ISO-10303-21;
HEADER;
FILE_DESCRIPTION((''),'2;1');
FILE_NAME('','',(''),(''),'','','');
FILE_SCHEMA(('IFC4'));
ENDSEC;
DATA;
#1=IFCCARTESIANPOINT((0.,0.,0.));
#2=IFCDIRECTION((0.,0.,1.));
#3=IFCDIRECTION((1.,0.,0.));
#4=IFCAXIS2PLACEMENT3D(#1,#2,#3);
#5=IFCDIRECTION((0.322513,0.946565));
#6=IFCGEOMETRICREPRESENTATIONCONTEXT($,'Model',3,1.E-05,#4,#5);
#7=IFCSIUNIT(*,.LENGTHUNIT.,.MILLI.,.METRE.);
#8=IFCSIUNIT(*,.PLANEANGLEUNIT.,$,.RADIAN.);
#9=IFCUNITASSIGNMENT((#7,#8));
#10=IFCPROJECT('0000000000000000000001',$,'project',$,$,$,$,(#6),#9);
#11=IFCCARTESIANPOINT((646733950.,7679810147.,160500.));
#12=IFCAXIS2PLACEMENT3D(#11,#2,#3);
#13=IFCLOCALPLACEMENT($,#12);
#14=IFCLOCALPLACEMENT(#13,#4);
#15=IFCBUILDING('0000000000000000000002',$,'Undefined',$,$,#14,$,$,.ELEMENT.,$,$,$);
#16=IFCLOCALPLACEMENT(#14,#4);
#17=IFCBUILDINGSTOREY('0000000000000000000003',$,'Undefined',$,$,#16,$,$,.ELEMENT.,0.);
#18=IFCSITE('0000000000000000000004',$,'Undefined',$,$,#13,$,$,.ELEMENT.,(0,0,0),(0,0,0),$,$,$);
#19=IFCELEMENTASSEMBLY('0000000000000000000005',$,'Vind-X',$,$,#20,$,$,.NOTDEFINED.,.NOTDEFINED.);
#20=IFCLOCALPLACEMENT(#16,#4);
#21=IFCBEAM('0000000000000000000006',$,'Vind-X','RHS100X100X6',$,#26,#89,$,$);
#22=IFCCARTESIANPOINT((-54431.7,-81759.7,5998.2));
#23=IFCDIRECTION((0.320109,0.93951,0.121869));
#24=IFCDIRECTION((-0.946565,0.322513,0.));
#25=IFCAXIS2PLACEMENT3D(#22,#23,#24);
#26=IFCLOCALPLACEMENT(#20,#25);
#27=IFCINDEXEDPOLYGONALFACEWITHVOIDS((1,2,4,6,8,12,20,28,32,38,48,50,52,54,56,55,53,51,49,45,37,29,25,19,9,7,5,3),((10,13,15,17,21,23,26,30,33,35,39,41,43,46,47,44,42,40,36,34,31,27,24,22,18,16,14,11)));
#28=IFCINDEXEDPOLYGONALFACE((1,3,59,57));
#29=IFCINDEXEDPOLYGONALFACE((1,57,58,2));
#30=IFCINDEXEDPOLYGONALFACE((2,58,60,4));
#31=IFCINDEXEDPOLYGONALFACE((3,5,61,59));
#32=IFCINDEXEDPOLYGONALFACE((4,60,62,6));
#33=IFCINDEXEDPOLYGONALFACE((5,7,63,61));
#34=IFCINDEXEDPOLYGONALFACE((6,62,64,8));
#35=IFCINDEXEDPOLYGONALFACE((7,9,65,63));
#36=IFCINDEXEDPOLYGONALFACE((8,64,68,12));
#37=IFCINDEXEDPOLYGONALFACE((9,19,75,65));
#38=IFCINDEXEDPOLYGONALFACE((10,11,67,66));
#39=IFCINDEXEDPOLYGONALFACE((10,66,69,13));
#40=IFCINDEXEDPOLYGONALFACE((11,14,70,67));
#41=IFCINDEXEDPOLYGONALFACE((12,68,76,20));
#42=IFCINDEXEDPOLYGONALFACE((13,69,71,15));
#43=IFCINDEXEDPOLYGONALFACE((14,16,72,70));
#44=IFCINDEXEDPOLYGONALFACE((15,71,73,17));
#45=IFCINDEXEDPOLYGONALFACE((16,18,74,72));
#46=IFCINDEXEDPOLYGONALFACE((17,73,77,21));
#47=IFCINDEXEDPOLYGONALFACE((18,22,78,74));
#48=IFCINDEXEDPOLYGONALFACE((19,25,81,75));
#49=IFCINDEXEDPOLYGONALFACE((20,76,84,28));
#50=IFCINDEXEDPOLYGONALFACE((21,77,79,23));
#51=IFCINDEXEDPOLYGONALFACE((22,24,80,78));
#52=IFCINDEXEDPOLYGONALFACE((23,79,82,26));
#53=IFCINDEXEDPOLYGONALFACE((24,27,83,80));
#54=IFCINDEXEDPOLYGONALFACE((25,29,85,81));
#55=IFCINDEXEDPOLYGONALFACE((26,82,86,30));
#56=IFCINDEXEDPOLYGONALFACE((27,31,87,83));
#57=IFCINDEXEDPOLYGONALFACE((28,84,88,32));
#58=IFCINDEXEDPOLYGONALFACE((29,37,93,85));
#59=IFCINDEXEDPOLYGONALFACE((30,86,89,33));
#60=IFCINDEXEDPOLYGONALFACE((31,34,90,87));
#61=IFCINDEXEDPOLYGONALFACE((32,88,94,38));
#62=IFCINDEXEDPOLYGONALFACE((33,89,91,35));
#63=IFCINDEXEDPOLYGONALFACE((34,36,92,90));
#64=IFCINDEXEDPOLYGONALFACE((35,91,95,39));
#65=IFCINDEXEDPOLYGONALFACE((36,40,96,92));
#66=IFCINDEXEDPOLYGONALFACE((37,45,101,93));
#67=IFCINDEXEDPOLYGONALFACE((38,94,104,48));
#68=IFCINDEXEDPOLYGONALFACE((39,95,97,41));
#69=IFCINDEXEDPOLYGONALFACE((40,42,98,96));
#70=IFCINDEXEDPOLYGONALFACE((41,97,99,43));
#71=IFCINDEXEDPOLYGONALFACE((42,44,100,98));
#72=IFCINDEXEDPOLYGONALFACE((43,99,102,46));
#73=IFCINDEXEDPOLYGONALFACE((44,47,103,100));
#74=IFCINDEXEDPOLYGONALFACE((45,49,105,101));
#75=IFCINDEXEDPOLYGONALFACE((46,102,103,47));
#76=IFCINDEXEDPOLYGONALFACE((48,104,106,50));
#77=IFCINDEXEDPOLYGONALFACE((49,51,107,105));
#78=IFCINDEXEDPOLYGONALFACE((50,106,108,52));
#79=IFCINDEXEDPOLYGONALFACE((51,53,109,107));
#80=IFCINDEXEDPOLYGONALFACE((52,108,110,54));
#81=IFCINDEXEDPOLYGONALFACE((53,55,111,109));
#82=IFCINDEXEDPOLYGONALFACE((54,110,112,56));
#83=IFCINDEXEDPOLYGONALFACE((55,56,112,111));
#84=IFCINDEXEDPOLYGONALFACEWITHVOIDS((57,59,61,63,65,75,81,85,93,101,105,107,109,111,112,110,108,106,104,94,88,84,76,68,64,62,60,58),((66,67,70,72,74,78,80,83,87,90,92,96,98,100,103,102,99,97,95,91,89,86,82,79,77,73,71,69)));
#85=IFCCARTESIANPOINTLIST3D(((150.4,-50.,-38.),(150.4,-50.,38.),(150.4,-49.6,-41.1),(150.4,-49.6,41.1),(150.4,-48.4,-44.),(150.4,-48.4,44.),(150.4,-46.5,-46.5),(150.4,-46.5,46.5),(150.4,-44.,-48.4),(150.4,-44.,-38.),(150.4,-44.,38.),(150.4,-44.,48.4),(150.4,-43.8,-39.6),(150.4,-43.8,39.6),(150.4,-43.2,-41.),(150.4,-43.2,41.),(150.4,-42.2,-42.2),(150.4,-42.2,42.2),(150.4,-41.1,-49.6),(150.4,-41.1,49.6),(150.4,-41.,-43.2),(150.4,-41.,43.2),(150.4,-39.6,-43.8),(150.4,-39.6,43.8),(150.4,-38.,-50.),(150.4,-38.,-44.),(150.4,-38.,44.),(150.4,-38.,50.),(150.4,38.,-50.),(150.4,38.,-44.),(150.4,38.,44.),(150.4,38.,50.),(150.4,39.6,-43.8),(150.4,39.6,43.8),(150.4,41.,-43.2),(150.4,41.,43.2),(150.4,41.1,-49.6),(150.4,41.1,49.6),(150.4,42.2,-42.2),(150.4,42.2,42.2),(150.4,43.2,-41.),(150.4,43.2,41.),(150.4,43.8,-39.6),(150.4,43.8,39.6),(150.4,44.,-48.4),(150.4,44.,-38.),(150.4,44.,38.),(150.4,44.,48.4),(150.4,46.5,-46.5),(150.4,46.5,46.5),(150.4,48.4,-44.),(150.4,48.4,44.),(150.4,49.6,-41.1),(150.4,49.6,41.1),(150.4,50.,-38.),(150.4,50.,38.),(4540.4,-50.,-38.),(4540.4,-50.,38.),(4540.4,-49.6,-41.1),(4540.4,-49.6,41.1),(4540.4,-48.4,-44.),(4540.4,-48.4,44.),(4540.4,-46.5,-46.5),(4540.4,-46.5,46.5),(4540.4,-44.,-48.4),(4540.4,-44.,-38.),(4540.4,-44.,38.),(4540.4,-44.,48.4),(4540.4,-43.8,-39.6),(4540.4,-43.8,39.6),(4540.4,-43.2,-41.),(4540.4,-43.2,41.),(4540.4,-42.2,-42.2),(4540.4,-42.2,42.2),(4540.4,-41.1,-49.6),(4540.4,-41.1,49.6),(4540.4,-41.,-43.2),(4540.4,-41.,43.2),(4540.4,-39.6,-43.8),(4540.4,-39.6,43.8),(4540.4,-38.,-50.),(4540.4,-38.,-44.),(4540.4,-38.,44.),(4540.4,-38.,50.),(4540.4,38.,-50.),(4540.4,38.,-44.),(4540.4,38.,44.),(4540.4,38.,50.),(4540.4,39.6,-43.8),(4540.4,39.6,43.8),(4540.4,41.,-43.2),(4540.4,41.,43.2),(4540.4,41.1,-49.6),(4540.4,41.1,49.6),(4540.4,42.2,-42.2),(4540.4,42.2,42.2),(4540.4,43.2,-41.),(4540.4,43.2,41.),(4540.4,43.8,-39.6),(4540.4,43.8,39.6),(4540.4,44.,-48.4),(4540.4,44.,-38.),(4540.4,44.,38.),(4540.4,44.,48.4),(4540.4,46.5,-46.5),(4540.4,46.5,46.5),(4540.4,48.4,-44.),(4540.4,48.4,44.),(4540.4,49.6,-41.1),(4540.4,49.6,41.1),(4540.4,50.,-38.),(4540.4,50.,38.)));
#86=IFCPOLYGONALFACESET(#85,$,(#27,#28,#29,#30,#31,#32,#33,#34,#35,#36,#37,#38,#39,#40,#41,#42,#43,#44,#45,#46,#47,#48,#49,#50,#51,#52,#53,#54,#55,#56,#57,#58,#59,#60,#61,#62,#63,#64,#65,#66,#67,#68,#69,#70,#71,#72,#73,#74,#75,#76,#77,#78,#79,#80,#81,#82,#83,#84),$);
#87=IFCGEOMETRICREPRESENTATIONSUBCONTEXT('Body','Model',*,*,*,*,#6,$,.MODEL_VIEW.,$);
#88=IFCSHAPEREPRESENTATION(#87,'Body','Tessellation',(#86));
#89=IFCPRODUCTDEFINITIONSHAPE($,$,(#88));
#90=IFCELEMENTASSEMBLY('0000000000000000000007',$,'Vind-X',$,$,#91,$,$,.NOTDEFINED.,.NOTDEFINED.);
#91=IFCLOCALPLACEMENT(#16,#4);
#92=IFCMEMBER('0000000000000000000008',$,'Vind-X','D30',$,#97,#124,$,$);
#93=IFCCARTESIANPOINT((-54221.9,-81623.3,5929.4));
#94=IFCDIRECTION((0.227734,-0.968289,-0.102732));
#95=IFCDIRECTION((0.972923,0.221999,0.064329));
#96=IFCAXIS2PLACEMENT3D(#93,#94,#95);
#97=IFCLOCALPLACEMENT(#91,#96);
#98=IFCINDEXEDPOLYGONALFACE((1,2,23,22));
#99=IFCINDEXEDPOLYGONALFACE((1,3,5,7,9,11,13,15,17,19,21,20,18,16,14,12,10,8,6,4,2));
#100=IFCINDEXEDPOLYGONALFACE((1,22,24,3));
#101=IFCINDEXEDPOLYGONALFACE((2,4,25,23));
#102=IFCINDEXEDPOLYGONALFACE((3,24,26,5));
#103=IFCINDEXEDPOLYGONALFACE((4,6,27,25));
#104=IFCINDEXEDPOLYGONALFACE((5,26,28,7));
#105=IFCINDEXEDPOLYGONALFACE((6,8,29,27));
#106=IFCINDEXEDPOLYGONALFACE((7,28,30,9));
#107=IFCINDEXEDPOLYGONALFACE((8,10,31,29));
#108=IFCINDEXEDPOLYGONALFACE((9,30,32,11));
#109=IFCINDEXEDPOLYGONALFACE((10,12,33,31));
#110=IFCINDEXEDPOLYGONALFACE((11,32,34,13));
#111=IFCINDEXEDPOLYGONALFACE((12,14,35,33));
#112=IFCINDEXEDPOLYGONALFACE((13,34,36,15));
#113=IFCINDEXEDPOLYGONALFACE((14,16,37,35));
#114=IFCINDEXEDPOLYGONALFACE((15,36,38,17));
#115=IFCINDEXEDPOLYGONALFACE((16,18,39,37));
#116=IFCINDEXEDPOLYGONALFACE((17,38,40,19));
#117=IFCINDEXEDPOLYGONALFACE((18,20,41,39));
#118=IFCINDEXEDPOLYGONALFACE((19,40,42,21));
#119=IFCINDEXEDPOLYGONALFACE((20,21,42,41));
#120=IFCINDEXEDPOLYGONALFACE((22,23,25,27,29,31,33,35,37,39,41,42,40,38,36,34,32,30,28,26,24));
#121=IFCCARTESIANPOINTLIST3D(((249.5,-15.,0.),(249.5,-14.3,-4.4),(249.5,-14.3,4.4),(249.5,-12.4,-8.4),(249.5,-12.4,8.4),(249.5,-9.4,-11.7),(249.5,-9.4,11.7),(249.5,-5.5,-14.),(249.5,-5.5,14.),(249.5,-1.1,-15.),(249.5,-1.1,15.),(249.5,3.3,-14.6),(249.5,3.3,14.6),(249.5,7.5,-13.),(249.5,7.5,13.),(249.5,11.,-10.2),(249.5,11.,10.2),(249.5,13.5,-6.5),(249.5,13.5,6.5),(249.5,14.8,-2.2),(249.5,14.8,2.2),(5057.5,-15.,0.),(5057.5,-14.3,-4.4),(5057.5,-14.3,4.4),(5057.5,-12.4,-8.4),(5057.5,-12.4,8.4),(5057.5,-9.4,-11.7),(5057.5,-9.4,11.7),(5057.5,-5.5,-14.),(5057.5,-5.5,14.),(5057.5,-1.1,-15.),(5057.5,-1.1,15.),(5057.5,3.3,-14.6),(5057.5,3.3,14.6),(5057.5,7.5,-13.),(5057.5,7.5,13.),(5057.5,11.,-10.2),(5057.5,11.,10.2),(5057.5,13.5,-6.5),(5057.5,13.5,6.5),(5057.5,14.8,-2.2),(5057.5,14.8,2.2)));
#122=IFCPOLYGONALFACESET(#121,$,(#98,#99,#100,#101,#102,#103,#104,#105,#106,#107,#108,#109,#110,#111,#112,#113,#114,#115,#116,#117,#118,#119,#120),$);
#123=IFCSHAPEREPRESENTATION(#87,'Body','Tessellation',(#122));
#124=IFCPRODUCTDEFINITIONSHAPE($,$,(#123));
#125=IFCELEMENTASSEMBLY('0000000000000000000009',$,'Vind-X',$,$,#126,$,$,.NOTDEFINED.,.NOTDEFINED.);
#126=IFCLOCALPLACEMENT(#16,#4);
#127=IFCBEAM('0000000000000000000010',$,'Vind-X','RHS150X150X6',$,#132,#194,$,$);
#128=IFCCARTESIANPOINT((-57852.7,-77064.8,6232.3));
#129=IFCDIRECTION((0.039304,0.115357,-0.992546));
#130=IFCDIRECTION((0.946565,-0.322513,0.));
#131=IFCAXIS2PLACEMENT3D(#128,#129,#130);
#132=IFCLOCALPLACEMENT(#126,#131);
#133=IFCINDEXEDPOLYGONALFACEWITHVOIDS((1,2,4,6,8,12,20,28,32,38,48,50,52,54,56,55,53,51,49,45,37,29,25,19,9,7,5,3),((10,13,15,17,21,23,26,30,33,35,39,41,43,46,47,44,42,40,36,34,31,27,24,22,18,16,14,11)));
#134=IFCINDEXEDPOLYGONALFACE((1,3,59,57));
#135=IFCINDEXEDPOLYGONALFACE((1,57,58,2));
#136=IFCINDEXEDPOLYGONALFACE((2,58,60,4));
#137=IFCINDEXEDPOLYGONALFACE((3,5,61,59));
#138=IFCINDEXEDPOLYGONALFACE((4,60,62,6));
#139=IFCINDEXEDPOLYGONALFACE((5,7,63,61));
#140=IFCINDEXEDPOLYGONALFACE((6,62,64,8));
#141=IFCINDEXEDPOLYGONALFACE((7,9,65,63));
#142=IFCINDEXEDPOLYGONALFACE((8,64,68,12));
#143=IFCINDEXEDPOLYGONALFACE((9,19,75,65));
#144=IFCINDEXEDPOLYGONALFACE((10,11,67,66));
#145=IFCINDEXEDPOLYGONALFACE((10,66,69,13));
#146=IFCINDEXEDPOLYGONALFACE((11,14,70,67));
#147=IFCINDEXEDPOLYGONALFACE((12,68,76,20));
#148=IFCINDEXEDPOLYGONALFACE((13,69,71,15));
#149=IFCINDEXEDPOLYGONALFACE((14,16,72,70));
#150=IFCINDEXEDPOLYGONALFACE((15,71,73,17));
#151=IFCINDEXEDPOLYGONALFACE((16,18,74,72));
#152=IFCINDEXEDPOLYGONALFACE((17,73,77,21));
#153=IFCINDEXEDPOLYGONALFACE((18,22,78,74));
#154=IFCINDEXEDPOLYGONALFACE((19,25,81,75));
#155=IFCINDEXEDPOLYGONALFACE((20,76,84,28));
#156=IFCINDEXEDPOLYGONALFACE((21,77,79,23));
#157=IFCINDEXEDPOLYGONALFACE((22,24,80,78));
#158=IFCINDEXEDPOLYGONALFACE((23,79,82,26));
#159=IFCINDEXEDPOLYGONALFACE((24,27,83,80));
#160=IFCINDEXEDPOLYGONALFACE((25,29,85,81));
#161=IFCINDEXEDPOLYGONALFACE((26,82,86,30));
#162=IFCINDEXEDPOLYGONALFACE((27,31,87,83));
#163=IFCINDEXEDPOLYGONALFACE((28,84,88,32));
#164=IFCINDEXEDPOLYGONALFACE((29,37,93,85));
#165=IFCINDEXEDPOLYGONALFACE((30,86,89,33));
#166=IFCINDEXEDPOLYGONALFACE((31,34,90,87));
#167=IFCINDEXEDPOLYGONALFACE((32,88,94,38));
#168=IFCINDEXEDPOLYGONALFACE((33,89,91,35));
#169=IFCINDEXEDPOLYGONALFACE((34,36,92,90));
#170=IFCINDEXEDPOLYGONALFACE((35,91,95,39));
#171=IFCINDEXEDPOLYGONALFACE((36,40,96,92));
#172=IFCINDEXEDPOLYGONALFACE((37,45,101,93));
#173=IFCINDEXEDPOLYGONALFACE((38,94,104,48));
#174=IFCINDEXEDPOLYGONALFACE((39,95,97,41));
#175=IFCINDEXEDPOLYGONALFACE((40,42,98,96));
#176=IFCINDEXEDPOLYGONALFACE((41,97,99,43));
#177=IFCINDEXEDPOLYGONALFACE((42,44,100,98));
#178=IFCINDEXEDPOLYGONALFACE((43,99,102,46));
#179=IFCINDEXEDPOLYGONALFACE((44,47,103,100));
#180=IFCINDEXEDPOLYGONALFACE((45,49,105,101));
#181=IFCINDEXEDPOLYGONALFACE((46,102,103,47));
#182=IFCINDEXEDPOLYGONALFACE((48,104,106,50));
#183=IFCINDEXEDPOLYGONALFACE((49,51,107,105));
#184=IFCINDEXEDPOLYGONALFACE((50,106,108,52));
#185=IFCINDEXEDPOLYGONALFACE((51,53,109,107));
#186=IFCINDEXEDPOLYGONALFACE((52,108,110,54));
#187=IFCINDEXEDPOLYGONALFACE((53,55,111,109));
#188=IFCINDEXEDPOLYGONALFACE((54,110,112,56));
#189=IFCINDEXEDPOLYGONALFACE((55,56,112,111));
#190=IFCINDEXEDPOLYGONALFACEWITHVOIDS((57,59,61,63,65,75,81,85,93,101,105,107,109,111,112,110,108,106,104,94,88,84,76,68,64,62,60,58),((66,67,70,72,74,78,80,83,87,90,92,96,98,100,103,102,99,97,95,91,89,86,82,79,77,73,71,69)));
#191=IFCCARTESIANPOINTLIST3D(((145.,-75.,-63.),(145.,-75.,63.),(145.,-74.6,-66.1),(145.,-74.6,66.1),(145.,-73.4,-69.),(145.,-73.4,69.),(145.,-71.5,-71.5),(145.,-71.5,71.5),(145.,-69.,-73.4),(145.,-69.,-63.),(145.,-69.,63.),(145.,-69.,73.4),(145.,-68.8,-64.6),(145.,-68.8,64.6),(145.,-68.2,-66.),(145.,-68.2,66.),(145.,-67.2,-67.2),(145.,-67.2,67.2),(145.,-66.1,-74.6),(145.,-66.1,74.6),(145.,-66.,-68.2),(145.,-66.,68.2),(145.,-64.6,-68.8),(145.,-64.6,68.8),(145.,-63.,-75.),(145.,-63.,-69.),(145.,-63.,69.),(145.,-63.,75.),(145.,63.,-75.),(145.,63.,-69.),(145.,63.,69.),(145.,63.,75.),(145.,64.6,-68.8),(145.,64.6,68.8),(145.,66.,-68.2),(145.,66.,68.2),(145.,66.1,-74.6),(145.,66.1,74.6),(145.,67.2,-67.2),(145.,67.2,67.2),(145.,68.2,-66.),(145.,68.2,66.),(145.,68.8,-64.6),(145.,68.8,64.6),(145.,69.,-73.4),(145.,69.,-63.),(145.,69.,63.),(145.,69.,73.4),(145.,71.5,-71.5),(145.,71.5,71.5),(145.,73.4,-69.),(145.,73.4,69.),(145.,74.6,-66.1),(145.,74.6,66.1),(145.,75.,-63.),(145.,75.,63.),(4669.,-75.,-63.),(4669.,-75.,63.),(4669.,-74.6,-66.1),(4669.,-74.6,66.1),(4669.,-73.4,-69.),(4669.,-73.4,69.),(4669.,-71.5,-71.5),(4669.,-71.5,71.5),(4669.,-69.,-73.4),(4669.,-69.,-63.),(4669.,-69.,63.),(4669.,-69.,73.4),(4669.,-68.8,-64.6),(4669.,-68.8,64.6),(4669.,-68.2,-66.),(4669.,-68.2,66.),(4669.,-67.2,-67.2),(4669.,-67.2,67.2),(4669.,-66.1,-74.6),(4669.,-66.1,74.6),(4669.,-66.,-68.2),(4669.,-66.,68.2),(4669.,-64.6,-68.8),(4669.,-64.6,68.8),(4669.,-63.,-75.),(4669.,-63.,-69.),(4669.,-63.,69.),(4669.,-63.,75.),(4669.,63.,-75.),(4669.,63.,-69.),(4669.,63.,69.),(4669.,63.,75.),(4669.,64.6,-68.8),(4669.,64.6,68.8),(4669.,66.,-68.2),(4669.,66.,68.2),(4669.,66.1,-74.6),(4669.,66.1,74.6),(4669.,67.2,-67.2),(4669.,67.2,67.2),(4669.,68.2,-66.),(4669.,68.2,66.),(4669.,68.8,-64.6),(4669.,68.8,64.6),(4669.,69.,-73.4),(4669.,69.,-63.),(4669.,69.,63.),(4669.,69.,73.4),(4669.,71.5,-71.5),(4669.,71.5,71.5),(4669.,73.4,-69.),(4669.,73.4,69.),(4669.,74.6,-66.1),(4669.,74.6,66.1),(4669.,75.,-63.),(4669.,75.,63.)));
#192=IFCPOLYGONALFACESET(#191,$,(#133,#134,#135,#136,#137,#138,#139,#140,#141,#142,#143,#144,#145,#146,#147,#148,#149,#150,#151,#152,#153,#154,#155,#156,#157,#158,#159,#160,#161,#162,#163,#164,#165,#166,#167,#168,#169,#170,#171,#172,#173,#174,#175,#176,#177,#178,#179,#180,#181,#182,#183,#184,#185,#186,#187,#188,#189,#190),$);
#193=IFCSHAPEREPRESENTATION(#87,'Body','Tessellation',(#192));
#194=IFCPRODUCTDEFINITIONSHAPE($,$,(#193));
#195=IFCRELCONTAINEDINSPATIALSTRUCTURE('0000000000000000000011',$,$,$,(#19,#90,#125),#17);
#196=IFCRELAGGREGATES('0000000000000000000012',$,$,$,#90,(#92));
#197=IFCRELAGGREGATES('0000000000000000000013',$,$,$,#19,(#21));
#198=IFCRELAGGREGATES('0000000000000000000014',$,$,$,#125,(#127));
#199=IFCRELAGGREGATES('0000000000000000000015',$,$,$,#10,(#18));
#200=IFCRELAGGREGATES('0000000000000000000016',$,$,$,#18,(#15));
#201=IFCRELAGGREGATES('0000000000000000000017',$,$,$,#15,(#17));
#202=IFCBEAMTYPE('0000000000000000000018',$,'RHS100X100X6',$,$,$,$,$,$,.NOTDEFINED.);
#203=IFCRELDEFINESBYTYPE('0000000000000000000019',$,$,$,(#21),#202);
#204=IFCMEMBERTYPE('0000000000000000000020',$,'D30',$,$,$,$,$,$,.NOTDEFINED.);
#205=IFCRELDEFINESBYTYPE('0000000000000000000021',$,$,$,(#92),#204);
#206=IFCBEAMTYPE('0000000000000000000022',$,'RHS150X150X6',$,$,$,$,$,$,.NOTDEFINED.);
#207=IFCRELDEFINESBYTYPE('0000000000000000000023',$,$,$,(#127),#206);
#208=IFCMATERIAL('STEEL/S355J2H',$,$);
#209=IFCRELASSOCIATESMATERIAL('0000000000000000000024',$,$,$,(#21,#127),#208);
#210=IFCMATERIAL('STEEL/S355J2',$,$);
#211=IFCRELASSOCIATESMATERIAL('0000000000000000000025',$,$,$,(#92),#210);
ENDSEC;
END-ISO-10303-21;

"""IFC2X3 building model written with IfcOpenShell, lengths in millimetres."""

from ifc_helpers import new_model, si_unit, direction, frame, origin_with_axes, origin_2d_with_axis, place, context, subcontext, project, spatial, hollow_rectangle, circle, extrude, clip, halfspace, material, type_object, element, aggregate, save


model = new_model("IFC2X3")

# Units and contexts
model_context = context("Model", 3, precision=1e-05, world=origin_with_axes(), true_north=direction((0.322513, 0.946565)))
body_context = subcontext(model_context, "Body", "Model", "MODEL_VIEW")
ifc_project = project(units=[si_unit("LENGTHUNIT", "METRE", prefix="MILLI"), si_unit("PLANEANGLEUNIT", "RADIAN")], contexts=[model_context])

# Site, building, storey
site_placement = place(None, frame((646733950.0, 7679810147.0, 160500.0), z_axis=(0.0, 0.0, 1.0), x_axis=(1.0, 0.0, 0.0)))
site = spatial("IfcSite", under=ifc_project, at=site_placement, Name="Undefined", CompositionType="ELEMENT", RefLatitude=(0, 0, 0), RefLongitude=(0, 0, 0))
building_placement = place(site_placement, origin_with_axes())
building = spatial("IfcBuilding", under=site, at=building_placement, Name="Undefined", CompositionType="ELEMENT")
storey_placement = place(building_placement, origin_with_axes())
storey = spatial("IfcBuildingStorey", under=building, at=storey_placement, Name="Undefined", CompositionType="ELEMENT", Elevation=0.0)

# Element assembly, beam
assembly_1_placement = place(storey_placement, origin_with_axes())
assembly_1 = element("IfcElementAssembly", 1, at=assembly_1_placement, inside=storey, Name="Vind-X", AssemblyPlace="NOTDEFINED", PredefinedType="NOTDEFINED")
ifc_material_1 = material(Name="STEEL/S355J2H")
beam_type_1 = type_object("IfcBeamType", Name="RHS100X100X6", PredefinedType="NOTDEFINED")
beam_1_placement = place(assembly_1_placement, frame((-54431.7, -81759.7, 5998.2), z_axis=(0.320109, 0.93951, 0.121869), x_axis=(-0.946565, 0.322513, 0.0)))
beam_1 = element("IfcBeam", 2, at=beam_1_placement, type_object=beam_type_1, material=ifc_material_1, Name="Vind-X", Description="RHS100X100X6", context=body_context, shape_type="Clipping", body=[
    clip(clip(extrude(hollow_rectangle(XDim=100.0, YDim=100.0, WallThickness=6.0, InnerFilletRadius=6.0, OuterFilletRadius=12.0, at=origin_2d_with_axis()), frame((4690.0, 0.0, 0.0), z_axis=(-1.0, 0.0, 0.0), x_axis=(0.0, -1.0, 0.0)), (0.0, 0.0, 1.0), 4690.0), halfspace(frame((4540.4, -22.5, 0.0), z_axis=(-1.0, 0.0, 0.0), x_axis=(0.0, 0.0, -1.0)), True)), halfspace(frame((150.4, -22.5, 0.0), z_axis=(1.0, 0.0, 0.0), x_axis=(0.0, 1.0, 0.0)), True)),
])

# Element assembly, member
assembly_2_placement = place(storey_placement, origin_with_axes())
assembly_2 = element("IfcElementAssembly", 3, at=assembly_2_placement, inside=storey, Name="Vind-X", AssemblyPlace="NOTDEFINED", PredefinedType="NOTDEFINED")
ifc_material_2 = material(Name="STEEL/S355J2")
member_type_1 = type_object("IfcMemberType", Name="D30", PredefinedType="NOTDEFINED")
member_1_placement = place(assembly_2_placement, frame((-54221.9, -81623.3, 5929.4), z_axis=(0.227734, -0.968289, -0.102732), x_axis=(0.972923, 0.221999, 0.064329)))
member_1 = element("IfcMember", 4, at=member_1_placement, type_object=member_type_1, material=ifc_material_2, Name="Vind-X", Description="D30", context=body_context, shape_type="Clipping", body=[
    clip(extrude(circle(Radius=15.0, at=origin_2d_with_axis()), frame((5057.5, 0.0, 0.0), z_axis=(-1.0, 0.0, 0.0), x_axis=(0.0, -1.0, 0.0)), (0.0, 0.0, 1.0), 5057.5), halfspace(frame((249.5, -22.5, 0.0), z_axis=(1.0, 0.0, 0.0), x_axis=(0.0, -0.000782, 1.0)), True)),
])
aggregate(assembly_2, [member_1])

# Element assembly, beam
assembly_3_placement = place(storey_placement, origin_with_axes())
assembly_3 = element("IfcElementAssembly", 5, at=assembly_3_placement, inside=storey, Name="Vind-X", AssemblyPlace="NOTDEFINED", PredefinedType="NOTDEFINED")
beam_type_2 = type_object("IfcBeamType", Name="RHS150X150X6", PredefinedType="NOTDEFINED")
beam_2_placement = place(assembly_3_placement, frame((-57852.7, -77064.8, 6232.3), z_axis=(0.039304, 0.115357, -0.992546), x_axis=(0.946565, -0.322513, 0.0)))
beam_2 = element("IfcBeam", 6, at=beam_2_placement, type_object=beam_type_2, material=ifc_material_1, Name="Vind-X", Description="RHS150X150X6", context=body_context, shape_type="Clipping", body=[
    clip(clip(extrude(hollow_rectangle(XDim=150.0, YDim=150.0, WallThickness=6.0, InnerFilletRadius=6.0, OuterFilletRadius=12.0, at=origin_2d_with_axis()), frame((4814.0, 0.0, 0.0), z_axis=(-1.0, 0.0, 0.0), x_axis=(0.0, -1.0, 0.0)), (0.0, 0.0, 1.0), 4814.0), halfspace(frame((4669.0, 0.0, 0.0), z_axis=(-1.0, 0.0, 0.0), x_axis=(0.0, 1.0, 0.0)), True)), halfspace(frame((145.0, 0.0, 0.0), z_axis=(1.0, 0.0, 0.0), x_axis=(0.0, -1.0, 0.0)), True)),
])

aggregate(assembly_1, [beam_1])
aggregate(assembly_3, [beam_2])

save(model, "model.ifc")
